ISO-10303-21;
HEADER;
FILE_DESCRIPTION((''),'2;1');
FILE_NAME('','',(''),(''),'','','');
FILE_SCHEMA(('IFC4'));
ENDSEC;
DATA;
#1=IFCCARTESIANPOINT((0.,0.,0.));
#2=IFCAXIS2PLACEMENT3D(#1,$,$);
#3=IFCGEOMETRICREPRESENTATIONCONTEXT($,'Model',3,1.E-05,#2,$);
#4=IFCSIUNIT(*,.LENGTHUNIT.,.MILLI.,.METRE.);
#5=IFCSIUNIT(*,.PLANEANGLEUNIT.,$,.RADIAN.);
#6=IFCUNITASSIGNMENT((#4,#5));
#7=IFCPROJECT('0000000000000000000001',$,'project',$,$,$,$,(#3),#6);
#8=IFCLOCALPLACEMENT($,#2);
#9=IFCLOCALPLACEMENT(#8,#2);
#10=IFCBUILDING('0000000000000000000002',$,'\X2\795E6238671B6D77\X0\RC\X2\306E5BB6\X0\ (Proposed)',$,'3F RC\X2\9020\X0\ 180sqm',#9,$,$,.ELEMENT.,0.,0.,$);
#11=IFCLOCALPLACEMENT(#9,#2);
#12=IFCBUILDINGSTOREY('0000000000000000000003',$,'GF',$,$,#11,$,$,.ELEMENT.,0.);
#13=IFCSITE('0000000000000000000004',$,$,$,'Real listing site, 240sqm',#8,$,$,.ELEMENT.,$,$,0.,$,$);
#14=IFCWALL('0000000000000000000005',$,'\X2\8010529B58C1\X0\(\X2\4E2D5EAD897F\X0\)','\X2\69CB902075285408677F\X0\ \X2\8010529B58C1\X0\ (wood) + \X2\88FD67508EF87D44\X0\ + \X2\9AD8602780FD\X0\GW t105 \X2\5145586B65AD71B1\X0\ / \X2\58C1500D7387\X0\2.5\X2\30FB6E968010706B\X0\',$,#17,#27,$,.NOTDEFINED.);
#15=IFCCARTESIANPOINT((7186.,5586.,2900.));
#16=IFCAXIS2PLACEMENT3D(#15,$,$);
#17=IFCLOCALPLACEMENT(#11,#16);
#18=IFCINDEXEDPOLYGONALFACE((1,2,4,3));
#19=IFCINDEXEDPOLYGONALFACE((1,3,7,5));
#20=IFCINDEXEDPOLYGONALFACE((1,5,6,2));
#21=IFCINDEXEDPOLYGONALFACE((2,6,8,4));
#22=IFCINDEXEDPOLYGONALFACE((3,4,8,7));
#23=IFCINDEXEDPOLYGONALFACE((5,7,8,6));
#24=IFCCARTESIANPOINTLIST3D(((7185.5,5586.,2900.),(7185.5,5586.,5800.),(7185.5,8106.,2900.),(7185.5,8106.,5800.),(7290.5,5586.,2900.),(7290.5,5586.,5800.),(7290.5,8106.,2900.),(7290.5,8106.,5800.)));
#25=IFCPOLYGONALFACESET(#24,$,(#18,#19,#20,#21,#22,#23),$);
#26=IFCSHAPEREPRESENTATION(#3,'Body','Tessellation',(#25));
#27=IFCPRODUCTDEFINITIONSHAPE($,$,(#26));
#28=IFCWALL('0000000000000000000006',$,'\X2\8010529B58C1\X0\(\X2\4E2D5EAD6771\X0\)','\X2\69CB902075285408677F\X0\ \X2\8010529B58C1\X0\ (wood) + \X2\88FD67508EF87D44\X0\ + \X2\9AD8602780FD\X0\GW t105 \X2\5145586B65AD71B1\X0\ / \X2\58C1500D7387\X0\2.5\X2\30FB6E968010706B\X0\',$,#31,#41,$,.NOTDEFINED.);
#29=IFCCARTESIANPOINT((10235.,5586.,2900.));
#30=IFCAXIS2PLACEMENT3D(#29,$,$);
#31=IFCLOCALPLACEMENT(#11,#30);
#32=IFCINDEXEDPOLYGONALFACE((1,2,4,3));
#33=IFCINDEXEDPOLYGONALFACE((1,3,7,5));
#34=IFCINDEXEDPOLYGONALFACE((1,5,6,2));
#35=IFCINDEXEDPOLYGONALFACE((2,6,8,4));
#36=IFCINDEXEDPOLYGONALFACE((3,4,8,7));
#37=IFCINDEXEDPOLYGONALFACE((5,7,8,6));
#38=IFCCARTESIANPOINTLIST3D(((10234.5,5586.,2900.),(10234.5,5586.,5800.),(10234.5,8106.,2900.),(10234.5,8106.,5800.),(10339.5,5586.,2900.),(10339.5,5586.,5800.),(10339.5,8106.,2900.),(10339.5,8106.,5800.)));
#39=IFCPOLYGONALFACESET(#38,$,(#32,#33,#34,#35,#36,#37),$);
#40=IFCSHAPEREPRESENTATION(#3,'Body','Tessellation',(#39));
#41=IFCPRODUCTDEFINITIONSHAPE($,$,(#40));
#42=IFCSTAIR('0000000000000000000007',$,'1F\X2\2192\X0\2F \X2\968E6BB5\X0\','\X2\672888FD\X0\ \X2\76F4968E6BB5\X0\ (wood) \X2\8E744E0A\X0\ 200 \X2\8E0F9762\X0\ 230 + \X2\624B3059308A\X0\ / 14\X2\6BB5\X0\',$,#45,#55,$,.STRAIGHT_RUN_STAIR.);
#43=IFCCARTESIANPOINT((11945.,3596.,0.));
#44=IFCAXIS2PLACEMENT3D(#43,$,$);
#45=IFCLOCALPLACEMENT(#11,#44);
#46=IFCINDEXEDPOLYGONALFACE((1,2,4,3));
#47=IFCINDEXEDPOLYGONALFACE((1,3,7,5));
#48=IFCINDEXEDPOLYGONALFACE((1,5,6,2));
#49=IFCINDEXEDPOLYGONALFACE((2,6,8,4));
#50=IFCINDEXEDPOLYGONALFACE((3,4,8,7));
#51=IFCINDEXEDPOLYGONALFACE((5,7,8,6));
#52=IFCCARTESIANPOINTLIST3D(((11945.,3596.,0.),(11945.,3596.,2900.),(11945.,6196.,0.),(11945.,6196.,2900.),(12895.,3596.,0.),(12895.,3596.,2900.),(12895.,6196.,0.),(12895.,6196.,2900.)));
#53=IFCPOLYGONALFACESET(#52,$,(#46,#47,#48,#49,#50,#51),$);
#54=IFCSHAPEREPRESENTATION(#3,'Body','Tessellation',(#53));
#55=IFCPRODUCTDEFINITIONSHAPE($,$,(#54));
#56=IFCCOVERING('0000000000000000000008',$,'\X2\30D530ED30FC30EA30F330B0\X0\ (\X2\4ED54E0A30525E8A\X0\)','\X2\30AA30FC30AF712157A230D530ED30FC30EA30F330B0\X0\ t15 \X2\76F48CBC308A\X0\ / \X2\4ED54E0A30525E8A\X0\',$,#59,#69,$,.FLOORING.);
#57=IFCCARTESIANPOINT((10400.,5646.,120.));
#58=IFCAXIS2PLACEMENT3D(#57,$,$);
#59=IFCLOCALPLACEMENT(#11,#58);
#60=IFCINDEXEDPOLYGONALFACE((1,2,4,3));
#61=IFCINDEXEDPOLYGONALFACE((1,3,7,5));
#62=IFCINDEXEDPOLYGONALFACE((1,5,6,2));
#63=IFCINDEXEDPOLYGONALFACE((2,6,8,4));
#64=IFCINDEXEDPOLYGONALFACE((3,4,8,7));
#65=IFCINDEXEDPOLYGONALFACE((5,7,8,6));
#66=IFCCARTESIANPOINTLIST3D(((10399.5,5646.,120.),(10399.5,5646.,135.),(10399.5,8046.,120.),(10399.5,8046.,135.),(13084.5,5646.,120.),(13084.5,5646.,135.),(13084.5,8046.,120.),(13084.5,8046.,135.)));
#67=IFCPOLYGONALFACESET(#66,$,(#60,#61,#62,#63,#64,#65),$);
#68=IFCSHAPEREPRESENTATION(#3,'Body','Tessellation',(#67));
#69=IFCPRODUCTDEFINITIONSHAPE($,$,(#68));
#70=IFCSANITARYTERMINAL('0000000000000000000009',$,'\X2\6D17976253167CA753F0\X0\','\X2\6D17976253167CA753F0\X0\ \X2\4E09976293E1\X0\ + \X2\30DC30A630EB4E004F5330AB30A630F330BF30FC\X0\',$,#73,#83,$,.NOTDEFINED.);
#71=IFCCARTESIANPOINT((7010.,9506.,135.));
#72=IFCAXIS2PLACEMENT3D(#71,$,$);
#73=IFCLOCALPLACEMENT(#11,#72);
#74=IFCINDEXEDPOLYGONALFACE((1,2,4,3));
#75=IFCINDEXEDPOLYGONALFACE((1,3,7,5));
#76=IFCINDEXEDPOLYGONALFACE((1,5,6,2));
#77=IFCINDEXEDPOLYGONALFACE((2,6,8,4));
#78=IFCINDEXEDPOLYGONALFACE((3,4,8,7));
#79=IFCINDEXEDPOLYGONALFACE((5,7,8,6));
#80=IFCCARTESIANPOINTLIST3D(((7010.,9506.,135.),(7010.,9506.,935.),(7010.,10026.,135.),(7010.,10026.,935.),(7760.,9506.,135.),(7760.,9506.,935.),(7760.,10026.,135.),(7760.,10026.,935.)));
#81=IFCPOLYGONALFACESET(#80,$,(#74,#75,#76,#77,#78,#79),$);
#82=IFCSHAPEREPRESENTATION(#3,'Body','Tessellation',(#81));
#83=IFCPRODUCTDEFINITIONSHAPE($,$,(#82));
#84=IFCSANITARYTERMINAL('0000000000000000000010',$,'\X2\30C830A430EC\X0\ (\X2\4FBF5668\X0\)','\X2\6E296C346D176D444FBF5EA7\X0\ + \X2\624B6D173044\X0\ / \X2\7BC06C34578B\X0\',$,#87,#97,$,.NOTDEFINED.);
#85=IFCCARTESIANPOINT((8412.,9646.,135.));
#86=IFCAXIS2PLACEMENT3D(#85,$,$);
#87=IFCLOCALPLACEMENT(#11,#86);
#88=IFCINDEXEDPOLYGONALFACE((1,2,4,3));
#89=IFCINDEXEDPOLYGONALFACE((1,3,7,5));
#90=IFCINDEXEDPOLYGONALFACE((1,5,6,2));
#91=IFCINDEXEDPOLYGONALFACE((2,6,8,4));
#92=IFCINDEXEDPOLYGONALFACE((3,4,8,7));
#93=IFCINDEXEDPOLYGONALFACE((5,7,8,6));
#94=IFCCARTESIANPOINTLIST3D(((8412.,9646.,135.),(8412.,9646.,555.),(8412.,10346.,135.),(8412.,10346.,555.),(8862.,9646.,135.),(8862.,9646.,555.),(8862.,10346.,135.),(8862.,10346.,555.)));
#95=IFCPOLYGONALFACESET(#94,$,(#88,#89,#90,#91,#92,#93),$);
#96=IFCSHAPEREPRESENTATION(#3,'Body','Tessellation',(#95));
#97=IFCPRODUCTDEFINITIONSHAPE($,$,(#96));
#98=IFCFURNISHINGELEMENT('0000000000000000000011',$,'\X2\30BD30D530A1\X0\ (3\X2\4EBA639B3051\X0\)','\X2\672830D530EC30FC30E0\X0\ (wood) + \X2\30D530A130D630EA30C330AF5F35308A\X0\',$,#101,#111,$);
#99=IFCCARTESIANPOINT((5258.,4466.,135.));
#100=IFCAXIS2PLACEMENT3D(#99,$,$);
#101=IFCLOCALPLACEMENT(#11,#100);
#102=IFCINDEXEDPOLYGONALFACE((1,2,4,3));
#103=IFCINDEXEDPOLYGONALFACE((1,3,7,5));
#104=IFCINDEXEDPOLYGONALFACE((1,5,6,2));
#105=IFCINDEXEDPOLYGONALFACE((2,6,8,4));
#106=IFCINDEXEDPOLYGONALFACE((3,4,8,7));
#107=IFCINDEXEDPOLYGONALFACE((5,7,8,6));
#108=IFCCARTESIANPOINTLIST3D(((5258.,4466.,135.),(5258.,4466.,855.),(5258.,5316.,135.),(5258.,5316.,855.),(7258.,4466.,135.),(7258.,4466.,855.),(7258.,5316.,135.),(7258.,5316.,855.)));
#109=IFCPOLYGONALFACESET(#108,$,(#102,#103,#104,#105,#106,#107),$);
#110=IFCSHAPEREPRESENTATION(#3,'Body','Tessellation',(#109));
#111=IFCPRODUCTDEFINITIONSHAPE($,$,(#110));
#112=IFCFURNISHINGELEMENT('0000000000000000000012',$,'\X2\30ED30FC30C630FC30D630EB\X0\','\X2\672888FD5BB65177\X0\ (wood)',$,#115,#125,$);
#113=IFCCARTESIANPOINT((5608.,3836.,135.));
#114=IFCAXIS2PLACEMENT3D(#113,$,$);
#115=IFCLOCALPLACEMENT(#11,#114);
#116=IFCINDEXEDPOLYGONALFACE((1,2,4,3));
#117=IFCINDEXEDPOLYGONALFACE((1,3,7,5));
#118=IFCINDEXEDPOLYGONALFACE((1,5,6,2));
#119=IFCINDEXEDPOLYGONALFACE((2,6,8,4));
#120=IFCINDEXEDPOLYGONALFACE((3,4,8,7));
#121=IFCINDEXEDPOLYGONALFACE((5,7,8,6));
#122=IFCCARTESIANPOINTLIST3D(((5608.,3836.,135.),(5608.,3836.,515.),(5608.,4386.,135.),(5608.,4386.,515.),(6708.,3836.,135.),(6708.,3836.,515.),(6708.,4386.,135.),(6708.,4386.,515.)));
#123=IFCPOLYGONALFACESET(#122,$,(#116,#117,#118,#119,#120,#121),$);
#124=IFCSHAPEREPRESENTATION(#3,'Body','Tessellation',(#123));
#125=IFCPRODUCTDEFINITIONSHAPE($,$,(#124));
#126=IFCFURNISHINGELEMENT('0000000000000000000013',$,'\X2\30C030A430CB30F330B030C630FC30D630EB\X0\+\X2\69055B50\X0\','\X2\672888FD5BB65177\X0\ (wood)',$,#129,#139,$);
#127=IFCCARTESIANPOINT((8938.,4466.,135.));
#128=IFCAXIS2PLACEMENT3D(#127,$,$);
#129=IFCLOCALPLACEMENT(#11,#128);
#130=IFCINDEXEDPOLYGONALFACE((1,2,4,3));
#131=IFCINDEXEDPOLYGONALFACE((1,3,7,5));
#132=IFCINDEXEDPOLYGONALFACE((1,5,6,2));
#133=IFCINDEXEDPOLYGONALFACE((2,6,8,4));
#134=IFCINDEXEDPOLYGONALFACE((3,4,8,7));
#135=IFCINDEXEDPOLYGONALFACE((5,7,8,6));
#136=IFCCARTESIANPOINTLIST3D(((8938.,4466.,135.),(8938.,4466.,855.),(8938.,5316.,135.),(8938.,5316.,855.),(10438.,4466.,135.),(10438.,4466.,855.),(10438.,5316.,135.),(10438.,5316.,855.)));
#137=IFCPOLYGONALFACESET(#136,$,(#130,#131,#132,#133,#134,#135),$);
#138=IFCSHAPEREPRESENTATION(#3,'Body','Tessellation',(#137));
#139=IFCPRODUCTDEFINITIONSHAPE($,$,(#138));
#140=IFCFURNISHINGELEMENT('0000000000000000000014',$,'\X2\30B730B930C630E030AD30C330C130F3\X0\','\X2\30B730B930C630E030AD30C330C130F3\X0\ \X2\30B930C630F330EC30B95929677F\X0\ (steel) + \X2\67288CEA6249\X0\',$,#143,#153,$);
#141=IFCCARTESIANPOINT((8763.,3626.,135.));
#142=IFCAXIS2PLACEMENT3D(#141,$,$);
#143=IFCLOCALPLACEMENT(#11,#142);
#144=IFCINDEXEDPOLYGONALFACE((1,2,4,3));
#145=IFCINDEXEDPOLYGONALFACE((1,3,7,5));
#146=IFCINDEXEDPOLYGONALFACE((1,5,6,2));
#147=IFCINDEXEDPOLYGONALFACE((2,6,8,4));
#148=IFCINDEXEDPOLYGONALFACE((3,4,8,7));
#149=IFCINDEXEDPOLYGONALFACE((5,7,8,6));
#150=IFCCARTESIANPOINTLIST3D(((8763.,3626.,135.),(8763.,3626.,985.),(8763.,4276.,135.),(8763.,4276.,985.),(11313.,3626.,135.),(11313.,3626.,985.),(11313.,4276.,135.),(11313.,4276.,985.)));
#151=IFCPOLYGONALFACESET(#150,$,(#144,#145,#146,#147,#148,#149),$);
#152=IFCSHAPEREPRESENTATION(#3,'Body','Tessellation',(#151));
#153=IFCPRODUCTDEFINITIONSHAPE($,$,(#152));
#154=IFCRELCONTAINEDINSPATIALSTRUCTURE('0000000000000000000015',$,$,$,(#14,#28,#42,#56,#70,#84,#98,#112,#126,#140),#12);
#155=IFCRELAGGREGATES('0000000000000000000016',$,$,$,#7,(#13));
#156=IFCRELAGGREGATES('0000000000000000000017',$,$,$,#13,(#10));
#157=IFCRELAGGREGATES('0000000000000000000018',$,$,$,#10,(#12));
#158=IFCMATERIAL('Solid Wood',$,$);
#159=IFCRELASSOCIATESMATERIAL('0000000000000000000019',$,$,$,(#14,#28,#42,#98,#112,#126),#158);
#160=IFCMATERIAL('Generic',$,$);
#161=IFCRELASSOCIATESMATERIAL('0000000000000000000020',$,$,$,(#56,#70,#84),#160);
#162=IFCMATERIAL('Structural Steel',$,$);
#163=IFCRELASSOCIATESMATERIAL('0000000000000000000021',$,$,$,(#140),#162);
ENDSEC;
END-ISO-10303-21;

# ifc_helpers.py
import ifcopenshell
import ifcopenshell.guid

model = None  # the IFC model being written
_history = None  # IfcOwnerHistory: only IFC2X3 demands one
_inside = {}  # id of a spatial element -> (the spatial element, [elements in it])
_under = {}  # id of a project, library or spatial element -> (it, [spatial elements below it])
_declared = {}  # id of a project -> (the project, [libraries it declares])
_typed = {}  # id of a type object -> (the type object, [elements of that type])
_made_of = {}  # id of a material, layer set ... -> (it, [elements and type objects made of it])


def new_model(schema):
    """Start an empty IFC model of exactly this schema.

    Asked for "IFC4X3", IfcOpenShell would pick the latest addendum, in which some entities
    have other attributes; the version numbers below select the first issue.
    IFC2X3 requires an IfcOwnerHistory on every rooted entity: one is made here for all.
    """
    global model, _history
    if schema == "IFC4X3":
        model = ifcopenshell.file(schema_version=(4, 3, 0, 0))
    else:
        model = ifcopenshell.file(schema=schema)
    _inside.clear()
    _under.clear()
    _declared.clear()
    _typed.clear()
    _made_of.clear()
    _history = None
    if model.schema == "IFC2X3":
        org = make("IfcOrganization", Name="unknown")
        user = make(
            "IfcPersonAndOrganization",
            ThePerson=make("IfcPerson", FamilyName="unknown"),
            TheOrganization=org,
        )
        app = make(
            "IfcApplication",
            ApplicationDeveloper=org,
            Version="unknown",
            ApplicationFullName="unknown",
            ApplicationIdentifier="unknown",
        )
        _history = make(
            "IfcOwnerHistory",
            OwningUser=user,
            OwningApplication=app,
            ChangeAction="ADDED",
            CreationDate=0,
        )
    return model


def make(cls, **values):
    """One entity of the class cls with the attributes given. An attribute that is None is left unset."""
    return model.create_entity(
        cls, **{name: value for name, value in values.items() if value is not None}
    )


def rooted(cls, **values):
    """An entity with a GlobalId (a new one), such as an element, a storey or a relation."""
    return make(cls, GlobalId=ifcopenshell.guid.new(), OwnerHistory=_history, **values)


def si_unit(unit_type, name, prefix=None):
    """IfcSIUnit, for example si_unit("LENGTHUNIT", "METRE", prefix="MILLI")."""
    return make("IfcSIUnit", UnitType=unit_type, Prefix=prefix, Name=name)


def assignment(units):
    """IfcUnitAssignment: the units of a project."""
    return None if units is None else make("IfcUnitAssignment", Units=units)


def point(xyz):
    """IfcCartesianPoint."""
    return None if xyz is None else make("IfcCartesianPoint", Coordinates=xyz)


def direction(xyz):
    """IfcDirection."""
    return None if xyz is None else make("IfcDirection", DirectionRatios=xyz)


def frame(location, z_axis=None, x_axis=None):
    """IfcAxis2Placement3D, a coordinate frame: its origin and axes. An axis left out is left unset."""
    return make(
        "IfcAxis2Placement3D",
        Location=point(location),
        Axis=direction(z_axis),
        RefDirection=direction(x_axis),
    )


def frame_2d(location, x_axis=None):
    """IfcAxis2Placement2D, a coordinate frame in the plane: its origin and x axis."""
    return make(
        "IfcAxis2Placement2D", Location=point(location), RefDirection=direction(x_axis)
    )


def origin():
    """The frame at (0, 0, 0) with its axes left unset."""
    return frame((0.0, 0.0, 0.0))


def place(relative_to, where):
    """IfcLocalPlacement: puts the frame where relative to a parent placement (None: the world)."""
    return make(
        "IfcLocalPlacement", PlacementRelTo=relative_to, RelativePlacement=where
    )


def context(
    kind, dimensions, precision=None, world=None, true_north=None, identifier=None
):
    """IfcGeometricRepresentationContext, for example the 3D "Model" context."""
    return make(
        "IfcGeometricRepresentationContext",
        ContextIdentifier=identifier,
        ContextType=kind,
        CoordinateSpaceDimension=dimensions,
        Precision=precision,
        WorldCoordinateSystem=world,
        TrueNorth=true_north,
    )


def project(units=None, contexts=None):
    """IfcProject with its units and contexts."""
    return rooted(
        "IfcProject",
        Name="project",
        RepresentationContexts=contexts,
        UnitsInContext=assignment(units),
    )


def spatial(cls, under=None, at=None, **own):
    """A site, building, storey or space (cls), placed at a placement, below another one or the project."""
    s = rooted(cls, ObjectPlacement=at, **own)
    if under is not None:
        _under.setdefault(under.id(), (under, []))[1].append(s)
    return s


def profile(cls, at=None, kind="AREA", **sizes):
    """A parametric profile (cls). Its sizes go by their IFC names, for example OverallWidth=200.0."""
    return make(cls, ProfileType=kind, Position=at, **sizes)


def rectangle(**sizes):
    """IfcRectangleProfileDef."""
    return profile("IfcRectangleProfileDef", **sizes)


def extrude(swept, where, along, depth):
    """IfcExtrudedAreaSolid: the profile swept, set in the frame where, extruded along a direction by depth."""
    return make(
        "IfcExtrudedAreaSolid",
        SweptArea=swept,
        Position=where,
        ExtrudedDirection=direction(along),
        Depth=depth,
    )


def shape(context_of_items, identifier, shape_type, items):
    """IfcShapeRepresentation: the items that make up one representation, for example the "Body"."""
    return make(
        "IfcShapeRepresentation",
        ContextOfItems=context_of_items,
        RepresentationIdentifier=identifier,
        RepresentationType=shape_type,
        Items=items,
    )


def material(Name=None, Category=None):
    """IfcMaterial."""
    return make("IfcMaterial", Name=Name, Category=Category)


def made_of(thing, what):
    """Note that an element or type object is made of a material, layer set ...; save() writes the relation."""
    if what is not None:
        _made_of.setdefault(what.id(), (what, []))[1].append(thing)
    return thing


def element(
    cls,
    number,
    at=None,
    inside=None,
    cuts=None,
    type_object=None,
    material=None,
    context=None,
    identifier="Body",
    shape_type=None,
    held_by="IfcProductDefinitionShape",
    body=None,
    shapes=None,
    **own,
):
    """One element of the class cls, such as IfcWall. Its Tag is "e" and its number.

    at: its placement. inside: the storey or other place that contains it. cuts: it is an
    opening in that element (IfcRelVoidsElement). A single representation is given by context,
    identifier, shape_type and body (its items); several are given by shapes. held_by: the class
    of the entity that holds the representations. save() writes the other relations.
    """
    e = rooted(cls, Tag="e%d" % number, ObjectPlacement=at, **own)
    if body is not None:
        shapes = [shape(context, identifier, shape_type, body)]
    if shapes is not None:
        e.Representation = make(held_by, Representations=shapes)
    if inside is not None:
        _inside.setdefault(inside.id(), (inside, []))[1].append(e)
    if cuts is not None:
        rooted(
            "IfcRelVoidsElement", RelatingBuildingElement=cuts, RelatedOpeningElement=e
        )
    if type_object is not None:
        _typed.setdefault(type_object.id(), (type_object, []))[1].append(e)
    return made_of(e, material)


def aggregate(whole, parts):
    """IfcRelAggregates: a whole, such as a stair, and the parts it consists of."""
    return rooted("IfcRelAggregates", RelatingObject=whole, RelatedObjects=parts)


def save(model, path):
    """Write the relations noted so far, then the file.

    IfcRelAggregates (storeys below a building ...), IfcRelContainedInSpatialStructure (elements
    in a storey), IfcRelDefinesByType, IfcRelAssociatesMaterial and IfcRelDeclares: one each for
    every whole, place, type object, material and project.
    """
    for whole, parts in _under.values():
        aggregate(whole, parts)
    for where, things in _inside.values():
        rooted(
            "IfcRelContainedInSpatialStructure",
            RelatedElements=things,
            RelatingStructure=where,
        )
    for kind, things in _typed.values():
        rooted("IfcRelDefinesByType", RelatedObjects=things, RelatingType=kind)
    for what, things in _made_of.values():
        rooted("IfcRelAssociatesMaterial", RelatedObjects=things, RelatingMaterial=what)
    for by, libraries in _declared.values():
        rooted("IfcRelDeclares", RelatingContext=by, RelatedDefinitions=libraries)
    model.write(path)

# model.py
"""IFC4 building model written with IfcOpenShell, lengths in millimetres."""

from ifc_helpers import new_model, si_unit, frame, frame_2d, origin, place, context, project, spatial, rectangle, extrude, material, element, save


model = new_model("IFC4")

# Units and contexts
model_context = context("Model", 3, precision=1e-05, world=origin())
ifc_project = project(units=[si_unit("LENGTHUNIT", "METRE", prefix="MILLI"), si_unit("PLANEANGLEUNIT", "RADIAN")], contexts=[model_context])

# Site, building, storey
site_placement = place(None, origin())
site = spatial("IfcSite", under=ifc_project, at=site_placement, ObjectType="Real listing site, 240sqm", CompositionType="ELEMENT", RefElevation=0.0)
building_placement = place(site_placement, origin())
building = spatial("IfcBuilding", under=site, at=building_placement, Name="神戸望海RCの家 (Proposed)", ObjectType="3F RC造 180sqm", CompositionType="ELEMENT", ElevationOfRefHeight=0.0, ElevationOfTerrain=0.0)
storey_placement = place(building_placement, origin())
storey = spatial("IfcBuildingStorey", under=building, at=storey_placement, Name="GF", CompositionType="ELEMENT", Elevation=0.0)

# Shared definitions
ifc_material_1 = material(Name="Solid Wood")

# Walls
wall_1_placement = place(storey_placement, frame((7186.0, 5586.0, 2900.0)))
element("IfcWall", 1, at=wall_1_placement, inside=storey, material=ifc_material_1, Name="耐力壁(中庭西)", Description="構造用合板 耐力壁 (wood) + 製材軸組 + 高性能GW t105 充填断熱 / 壁倍率2.5・準耐火", PredefinedType="NOTDEFINED", context=model_context, shape_type="SweptSolid", body=[
    extrude(rectangle(XDim=105.0, YDim=2520.0, at=frame_2d((52.0, 1260.0))), frame((7186.0, 5586.0, 2900.0)), (0.0, 0.0, 1.0), 2900.0),
])
wall_2_placement = place(storey_placement, frame((10235.0, 5586.0, 2900.0)))
element("IfcWall", 2, at=wall_2_placement, inside=storey, material=ifc_material_1, Name="耐力壁(中庭東)", Description="構造用合板 耐力壁 (wood) + 製材軸組 + 高性能GW t105 充填断熱 / 壁倍率2.5・準耐火", PredefinedType="NOTDEFINED", context=model_context, shape_type="SweptSolid", body=[
    extrude(rectangle(XDim=105.0, YDim=2520.0, at=frame_2d((52.0, 1260.0))), frame((10235.0, 5586.0, 2900.0)), (0.0, 0.0, 1.0), 2900.0),
])

# Stair
stair_placement = place(storey_placement, frame((11945.0, 3596.0, 0.0)))
element("IfcStair", 3, at=stair_placement, inside=storey, material=ifc_material_1, Name="1F→2F 階段", Description="木製 直階段 (wood) 蹴上 200 踏面 230 + 手すり / 14段", PredefinedType="STRAIGHT_RUN_STAIR", context=model_context, shape_type="SweptSolid", body=[
    extrude(rectangle(XDim=950.0, YDim=2600.0, at=frame_2d((475.0, 1300.0))), frame((11945.0, 3596.0, 0.0)), (0.0, 0.0, 1.0), 2900.0),
])

# Covering
ifc_material_2 = material(Name="Generic")
covering_placement = place(storey_placement, frame((10400.0, 5646.0, 120.0)))
element("IfcCovering", 4, at=covering_placement, inside=storey, material=ifc_material_2, Name="フローリング (仕上げ床)", Description="オーク無垢フローリング t15 直貼り / 仕上げ床", PredefinedType="FLOORING", context=model_context, shape_type="SweptSolid", body=[
    extrude(rectangle(XDim=2685.0, YDim=2400.0, at=frame_2d((1342.0, 1200.0))), frame((10400.0, 5646.0, 120.0)), (0.0, 0.0, 1.0), 15.0),
])

# Sanitary terminals
sanitary_terminal_1_placement = place(storey_placement, frame((7010.0, 9506.0, 135.0)))
element("IfcSanitaryTerminal", 5, at=sanitary_terminal_1_placement, inside=storey, material=ifc_material_2, Name="洗面化粧台", Description="洗面化粧台 三面鏡 + ボウル一体カウンター", PredefinedType="NOTDEFINED", context=model_context, shape_type="SweptSolid", body=[
    extrude(rectangle(XDim=750.0, YDim=520.0, at=frame_2d((375.0, 260.0))), frame((7010.0, 9506.0, 135.0)), (0.0, 0.0, 1.0), 800.0),
])
sanitary_terminal_2_placement = place(storey_placement, frame((8412.0, 9646.0, 135.0)))
element("IfcSanitaryTerminal", 6, at=sanitary_terminal_2_placement, inside=storey, material=ifc_material_2, Name="トイレ (便器)", Description="温水洗浄便座 + 手洗い / 節水型", PredefinedType="NOTDEFINED", context=model_context, shape_type="SweptSolid", body=[
    extrude(rectangle(XDim=450.0, YDim=700.0, at=frame_2d((225.0, 350.0))), frame((8412.0, 9646.0, 135.0)), (0.0, 0.0, 1.0), 420.0),
])

# Furnishing elements
furnishing_1_placement = place(storey_placement, frame((5258.0, 4466.0, 135.0)))
element("IfcFurnishingElement", 7, at=furnishing_1_placement, inside=storey, material=ifc_material_1, Name="ソファ (3人掛け)", Description="木フレーム (wood) + ファブリック張り", context=model_context, shape_type="SweptSolid", body=[
    extrude(rectangle(XDim=2000.0, YDim=850.0, at=frame_2d((1000.0, 425.0))), frame((5258.0, 4466.0, 135.0)), (0.0, 0.0, 1.0), 720.0),
])
furnishing_2_placement = place(storey_placement, frame((5608.0, 3836.0, 135.0)))
element("IfcFurnishingElement", 8, at=furnishing_2_placement, inside=storey, material=ifc_material_1, Name="ローテーブル", Description="木製家具 (wood)", context=model_context, shape_type="SweptSolid", body=[
    extrude(rectangle(XDim=1100.0, YDim=550.0, at=frame_2d((550.0, 275.0))), frame((5608.0, 3836.0, 135.0)), (0.0, 0.0, 1.0), 380.0),
])
furnishing_3_placement = place(storey_placement, frame((8938.0, 4466.0, 135.0)))
element("IfcFurnishingElement", 9, at=furnishing_3_placement, inside=storey, material=ifc_material_1, Name="ダイニングテーブル+椅子", Description="木製家具 (wood)", context=model_context, shape_type="SweptSolid", body=[
    extrude(rectangle(XDim=1500.0, YDim=850.0, at=frame_2d((750.0, 425.0))), frame((8938.0, 4466.0, 135.0)), (0.0, 0.0, 1.0), 720.0),
])
ifc_material_3 = material(Name="Structural Steel")
furnishing_4_placement = place(storey_placement, frame((8763.0, 3626.0, 135.0)))
element("IfcFurnishingElement", 10, at=furnishing_4_placement, inside=storey, material=ifc_material_3, Name="システムキッチン", Description="システムキッチン ステンレス天板 (steel) + 木質扉", context=model_context, shape_type="SweptSolid", body=[
    extrude(rectangle(XDim=2550.0, YDim=650.0, at=frame_2d((1275.0, 325.0))), frame((8763.0, 3626.0, 135.0)), (0.0, 0.0, 1.0), 850.0),
])

save(model, "model.ifc")
